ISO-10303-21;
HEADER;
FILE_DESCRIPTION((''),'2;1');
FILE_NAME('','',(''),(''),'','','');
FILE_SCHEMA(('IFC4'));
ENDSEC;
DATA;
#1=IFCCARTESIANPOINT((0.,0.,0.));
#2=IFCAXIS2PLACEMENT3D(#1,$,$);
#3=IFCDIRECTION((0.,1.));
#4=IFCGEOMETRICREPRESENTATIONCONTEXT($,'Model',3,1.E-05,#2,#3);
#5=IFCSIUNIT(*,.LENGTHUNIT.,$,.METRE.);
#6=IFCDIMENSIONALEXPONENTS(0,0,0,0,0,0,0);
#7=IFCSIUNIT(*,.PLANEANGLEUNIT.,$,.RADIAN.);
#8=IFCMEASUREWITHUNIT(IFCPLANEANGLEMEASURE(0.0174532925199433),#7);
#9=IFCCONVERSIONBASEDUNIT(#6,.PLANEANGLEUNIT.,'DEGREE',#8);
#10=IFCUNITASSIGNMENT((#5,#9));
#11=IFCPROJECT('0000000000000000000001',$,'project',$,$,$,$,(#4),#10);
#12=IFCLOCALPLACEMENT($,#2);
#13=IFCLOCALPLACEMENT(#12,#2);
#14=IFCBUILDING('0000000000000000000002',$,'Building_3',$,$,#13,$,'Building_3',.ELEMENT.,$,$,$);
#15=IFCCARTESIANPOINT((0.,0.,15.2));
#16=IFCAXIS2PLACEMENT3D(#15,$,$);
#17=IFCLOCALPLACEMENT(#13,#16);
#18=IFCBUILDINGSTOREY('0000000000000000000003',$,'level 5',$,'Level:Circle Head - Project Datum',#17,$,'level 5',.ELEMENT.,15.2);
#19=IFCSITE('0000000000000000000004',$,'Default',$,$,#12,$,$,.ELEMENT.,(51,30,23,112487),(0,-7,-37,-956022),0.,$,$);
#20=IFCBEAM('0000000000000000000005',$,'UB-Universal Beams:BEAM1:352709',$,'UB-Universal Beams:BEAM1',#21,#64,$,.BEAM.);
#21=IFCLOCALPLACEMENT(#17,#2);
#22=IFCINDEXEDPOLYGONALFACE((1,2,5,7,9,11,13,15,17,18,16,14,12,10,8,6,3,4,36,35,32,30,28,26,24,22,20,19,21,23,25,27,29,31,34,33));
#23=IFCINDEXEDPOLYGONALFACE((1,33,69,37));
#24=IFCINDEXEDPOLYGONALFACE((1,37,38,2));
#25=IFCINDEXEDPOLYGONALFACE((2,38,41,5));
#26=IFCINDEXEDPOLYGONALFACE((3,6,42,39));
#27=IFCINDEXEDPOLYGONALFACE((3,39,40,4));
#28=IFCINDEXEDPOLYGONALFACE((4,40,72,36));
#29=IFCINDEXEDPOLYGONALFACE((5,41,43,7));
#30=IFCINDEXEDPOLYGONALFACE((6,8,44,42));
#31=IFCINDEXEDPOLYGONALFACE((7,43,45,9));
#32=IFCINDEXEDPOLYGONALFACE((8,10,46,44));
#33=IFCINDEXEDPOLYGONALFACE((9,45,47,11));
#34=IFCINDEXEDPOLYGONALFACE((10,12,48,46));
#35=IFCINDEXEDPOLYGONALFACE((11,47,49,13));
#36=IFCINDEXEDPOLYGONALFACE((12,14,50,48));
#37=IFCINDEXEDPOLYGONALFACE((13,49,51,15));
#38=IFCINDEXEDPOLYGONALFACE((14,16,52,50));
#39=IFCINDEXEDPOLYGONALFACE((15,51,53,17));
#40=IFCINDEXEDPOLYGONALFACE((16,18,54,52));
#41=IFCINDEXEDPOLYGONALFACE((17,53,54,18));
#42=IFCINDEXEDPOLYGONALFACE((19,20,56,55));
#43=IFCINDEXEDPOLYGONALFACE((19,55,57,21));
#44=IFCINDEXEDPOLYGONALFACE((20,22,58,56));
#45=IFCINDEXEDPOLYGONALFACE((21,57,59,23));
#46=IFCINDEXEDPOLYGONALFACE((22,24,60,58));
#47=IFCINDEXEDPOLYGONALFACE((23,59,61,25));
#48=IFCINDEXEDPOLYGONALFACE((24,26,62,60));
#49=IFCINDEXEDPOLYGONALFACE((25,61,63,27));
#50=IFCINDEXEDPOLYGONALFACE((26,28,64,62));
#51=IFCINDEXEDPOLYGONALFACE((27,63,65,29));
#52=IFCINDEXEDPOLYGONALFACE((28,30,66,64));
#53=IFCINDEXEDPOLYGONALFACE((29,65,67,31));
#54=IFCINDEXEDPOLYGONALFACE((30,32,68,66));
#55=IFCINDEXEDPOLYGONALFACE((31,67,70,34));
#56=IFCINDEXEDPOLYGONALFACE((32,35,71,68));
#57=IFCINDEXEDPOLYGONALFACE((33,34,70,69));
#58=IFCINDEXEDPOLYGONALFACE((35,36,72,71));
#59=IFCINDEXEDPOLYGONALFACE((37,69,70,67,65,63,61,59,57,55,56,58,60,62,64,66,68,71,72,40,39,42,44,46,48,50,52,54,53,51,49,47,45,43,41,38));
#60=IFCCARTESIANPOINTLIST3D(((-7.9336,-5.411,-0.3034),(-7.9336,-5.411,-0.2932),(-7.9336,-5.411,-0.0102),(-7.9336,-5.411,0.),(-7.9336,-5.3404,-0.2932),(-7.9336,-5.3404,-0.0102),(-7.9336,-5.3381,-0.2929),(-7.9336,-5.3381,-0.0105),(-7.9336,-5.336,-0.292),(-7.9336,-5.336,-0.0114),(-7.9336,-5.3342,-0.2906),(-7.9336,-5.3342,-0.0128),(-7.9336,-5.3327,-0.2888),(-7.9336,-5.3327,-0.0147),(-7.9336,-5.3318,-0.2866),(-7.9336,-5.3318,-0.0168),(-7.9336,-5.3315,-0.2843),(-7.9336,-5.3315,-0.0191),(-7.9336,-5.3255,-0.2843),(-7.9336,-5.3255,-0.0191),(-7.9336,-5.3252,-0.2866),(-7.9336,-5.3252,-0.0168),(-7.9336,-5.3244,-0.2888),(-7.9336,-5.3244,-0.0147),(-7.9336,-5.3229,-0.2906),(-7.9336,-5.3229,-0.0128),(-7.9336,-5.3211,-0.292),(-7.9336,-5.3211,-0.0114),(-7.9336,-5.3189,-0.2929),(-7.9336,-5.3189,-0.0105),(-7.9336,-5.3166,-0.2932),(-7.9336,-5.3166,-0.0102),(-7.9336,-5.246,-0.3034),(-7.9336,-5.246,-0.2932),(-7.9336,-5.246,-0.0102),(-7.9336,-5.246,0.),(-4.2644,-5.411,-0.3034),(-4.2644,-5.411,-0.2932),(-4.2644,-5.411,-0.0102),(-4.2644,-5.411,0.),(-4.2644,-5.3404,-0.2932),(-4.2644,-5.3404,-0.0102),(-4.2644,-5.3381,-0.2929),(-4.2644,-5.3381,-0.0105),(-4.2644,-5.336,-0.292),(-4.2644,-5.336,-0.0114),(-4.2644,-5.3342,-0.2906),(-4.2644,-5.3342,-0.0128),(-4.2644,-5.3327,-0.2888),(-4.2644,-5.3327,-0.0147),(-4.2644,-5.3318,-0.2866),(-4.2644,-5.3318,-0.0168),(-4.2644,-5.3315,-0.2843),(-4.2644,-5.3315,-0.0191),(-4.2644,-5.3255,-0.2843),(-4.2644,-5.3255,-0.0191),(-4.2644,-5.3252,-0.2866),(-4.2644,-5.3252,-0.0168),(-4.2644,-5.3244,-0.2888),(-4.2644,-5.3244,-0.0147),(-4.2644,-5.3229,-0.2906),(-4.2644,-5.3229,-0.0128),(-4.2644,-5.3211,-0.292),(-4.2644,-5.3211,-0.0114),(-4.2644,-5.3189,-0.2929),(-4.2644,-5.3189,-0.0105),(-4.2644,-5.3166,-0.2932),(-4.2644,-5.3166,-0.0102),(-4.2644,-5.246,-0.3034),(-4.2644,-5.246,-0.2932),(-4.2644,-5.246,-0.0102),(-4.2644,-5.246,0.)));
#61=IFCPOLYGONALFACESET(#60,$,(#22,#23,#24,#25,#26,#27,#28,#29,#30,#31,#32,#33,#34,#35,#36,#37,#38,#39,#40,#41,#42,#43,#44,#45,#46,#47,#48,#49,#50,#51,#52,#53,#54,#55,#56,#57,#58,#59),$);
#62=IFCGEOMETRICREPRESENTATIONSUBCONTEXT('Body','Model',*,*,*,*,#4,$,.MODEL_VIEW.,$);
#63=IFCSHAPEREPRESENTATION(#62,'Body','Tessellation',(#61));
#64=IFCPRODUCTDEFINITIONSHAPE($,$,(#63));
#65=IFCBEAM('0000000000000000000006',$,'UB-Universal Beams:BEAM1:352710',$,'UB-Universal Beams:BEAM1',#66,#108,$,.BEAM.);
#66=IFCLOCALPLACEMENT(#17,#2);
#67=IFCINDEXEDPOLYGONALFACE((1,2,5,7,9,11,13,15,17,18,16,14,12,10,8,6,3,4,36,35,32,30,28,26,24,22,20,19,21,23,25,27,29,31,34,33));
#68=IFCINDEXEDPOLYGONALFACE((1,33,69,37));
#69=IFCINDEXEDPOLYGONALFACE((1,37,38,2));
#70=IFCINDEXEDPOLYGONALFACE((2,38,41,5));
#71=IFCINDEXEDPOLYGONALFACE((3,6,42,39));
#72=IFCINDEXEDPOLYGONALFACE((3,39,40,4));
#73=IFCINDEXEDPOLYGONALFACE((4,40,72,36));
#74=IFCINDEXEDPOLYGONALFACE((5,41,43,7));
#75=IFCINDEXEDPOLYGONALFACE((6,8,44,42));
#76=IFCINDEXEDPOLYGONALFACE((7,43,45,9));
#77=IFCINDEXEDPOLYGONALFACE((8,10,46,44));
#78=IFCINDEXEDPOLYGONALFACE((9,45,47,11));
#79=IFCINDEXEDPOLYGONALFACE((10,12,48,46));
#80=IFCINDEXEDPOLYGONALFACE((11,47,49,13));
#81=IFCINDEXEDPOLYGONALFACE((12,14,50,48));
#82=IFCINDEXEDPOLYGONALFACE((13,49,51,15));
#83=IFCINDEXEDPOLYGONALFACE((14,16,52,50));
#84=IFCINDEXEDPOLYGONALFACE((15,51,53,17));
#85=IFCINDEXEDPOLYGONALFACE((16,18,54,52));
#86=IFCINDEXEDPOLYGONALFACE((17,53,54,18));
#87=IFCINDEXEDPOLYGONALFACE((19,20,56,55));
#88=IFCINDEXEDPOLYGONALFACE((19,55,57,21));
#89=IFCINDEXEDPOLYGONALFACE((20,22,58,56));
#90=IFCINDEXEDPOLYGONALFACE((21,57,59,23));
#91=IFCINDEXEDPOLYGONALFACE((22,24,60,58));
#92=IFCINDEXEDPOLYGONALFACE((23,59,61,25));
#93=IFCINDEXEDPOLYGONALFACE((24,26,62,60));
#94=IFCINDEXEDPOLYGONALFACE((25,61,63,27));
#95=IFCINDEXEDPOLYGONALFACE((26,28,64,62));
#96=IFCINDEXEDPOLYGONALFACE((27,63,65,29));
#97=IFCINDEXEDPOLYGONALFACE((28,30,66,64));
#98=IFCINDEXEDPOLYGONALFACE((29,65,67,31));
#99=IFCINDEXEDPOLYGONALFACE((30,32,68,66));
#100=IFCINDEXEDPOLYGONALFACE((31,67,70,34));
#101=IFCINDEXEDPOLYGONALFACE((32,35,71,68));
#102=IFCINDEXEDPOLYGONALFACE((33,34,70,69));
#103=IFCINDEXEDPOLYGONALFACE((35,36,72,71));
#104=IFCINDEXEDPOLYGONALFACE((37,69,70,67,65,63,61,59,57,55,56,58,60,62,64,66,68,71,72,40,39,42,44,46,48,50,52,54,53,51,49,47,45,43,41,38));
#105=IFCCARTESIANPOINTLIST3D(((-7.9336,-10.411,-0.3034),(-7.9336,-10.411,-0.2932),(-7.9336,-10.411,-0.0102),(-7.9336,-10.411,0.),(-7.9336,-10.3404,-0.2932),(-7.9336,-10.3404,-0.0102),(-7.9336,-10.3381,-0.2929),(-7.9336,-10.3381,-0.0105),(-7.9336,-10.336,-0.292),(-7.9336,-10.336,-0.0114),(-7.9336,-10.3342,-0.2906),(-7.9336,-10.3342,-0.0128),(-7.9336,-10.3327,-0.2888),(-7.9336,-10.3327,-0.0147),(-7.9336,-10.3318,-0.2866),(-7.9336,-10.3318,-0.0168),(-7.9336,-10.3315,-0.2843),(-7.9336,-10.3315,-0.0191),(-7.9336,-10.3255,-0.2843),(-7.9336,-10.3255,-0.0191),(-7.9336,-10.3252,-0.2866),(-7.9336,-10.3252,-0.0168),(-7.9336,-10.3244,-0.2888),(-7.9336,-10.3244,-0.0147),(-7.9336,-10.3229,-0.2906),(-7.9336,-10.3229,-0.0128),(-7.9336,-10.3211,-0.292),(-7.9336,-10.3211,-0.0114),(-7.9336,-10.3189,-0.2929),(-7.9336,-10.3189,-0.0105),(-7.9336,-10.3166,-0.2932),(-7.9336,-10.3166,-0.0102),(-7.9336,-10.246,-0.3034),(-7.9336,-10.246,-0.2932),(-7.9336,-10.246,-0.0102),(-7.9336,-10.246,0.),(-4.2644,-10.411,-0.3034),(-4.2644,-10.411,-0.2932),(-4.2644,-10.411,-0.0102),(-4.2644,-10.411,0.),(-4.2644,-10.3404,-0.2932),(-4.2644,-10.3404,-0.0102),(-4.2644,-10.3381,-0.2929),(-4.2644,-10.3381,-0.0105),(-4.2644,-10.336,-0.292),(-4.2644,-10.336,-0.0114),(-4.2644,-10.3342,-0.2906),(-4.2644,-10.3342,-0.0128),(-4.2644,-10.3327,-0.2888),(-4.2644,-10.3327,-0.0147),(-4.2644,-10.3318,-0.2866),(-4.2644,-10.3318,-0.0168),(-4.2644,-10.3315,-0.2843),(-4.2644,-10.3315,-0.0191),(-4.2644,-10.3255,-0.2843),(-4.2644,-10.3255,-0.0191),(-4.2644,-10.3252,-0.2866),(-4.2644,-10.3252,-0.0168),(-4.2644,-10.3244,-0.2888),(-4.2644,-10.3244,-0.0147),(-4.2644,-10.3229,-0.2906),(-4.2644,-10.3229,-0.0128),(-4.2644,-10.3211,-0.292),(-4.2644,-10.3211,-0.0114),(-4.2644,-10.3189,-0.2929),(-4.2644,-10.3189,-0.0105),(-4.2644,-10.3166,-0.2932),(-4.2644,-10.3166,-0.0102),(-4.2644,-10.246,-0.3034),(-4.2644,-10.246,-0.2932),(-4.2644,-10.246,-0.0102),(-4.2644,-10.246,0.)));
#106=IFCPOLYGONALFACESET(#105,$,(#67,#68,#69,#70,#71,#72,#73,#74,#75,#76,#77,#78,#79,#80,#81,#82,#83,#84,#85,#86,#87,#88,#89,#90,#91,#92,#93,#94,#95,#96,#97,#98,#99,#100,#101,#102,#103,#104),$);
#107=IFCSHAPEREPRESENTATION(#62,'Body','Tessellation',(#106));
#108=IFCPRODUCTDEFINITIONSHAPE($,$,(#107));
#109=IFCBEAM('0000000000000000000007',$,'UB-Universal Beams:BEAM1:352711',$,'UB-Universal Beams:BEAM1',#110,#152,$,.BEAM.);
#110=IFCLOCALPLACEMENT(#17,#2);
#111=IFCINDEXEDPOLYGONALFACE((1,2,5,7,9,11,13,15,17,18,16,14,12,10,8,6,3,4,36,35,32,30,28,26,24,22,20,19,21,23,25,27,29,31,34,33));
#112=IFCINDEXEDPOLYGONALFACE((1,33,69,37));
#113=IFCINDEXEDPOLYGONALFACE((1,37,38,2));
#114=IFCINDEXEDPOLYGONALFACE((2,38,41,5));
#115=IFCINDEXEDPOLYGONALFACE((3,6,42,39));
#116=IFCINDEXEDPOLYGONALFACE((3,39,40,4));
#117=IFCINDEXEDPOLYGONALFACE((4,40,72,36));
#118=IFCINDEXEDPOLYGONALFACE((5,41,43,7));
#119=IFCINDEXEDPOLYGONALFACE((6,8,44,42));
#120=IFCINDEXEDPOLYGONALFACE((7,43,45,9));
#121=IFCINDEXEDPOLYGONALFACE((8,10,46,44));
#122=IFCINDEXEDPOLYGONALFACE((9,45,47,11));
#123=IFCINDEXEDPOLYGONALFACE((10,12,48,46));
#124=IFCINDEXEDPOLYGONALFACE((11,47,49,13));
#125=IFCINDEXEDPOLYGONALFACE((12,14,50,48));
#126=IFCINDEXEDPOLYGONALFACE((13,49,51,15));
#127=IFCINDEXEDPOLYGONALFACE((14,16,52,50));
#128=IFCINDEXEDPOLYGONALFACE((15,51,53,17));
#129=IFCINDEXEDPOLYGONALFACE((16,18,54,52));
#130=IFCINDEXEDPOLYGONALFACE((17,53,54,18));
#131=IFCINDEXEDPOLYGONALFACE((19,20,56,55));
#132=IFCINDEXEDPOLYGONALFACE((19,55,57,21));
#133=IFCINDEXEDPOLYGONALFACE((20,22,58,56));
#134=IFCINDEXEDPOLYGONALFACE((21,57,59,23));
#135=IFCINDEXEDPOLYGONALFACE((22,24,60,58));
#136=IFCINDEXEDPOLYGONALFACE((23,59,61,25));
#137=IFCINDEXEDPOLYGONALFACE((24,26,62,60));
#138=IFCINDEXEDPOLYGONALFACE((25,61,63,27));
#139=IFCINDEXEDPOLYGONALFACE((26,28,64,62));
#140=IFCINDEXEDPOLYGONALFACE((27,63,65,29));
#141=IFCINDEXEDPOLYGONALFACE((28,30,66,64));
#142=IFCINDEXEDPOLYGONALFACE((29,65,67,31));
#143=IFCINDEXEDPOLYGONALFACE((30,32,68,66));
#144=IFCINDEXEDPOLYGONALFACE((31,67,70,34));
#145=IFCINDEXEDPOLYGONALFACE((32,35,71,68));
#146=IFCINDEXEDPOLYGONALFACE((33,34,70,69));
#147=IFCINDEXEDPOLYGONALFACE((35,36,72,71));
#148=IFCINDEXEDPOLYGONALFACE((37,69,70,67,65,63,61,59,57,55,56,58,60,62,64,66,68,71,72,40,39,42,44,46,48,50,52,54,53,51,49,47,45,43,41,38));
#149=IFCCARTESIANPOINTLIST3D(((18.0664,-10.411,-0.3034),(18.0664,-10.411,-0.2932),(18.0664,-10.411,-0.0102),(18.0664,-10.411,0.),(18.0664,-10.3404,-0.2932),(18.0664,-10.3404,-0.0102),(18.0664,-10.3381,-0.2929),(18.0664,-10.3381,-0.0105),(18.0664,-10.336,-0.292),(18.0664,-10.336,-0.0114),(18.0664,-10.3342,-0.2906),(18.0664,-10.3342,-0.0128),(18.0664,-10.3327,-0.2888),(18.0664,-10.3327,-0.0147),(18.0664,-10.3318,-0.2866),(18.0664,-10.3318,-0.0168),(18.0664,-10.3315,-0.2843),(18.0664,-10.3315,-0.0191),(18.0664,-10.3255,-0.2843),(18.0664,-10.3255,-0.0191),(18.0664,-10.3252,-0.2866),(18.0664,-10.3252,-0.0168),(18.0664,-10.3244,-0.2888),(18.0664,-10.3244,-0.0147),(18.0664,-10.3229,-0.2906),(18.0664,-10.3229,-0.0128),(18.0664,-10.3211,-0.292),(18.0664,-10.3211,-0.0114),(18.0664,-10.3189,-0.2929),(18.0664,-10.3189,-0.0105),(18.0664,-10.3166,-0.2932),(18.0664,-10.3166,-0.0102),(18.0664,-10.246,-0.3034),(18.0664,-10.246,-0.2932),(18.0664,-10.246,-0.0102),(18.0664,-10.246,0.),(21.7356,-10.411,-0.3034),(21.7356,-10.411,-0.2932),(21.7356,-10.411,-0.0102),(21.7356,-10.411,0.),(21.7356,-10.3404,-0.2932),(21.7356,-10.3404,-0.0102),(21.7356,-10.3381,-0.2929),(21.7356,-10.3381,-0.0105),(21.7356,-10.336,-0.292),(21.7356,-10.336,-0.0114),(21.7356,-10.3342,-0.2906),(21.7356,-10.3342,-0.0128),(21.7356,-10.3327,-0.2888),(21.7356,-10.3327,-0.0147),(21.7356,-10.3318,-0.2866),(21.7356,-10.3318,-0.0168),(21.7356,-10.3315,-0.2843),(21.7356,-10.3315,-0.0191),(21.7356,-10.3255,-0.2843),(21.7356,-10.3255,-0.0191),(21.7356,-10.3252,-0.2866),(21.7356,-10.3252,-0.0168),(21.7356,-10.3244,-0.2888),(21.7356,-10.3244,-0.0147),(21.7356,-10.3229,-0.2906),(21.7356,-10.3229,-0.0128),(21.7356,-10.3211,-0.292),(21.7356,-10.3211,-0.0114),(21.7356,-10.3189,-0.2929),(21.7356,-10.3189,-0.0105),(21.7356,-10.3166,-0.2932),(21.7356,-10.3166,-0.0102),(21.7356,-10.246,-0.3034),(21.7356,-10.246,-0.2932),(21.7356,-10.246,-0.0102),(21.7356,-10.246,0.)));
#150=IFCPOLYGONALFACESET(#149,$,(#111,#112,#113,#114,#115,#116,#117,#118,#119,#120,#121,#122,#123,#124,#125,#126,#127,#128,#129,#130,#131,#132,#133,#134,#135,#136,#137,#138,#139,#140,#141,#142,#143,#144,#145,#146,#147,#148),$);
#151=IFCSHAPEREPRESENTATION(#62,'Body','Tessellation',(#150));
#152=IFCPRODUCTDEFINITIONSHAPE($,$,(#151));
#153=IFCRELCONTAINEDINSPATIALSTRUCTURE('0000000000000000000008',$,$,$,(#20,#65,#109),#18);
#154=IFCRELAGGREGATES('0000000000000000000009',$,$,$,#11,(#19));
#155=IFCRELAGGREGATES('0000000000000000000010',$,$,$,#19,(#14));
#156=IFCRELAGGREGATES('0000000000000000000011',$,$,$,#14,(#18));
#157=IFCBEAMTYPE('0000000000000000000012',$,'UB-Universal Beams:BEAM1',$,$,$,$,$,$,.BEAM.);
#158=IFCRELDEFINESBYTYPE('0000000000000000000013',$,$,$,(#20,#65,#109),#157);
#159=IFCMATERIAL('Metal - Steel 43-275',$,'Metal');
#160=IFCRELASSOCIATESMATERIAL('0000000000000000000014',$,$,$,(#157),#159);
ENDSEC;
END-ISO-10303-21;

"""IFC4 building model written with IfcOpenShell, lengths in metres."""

from ifc_helpers import new_model, entity, si_unit, converted_unit, direction, frame, frame_2d, origin, place, context, subcontext, project, spatial, polyline, circle_curve, parameter, trimmed, segment, composite_curve, outline, extrude, source, transform, mapped, material, material_profile, profile_set, type_object, type_shapes, element, save


model = new_model("IFC4")

# Units and contexts
model_context = context("Model", 3, precision=1e-05, world=origin(), true_north=direction((0.0, 1.0)))
body_context = subcontext(model_context, "Body", "Model", "MODEL_VIEW")
ifc_project = project(units=[si_unit("LENGTHUNIT", "METRE"), converted_unit("PLANEANGLEUNIT", "DEGREE", entity("IfcPlaneAngleMeasure", 0.0174532925199433), si_unit("PLANEANGLEUNIT", "RADIAN"), dimensions=[0, 0, 0, 0, 0, 0, 0])], contexts=[model_context])

# Site, building, storey
site_placement = place(None, origin())
site = spatial("IfcSite", under=ifc_project, at=site_placement, Name="Default", CompositionType="ELEMENT", RefLatitude=(51, 30, 23, 112487), RefLongitude=(0, -7, -37, -956022), RefElevation=0.0)
building_placement = place(site_placement, origin())
building = spatial("IfcBuilding", under=site, at=building_placement, Name="Building_3", LongName="Building_3", CompositionType="ELEMENT")
storey_placement = place(building_placement, frame((0.0, 0.0, 15.2)))
storey = spatial("IfcBuildingStorey", under=building, at=storey_placement, Name="level 5", ObjectType="Level:Circle Head - Project Datum", LongName="level 5", CompositionType="ELEMENT", Elevation=15.2)

# Beams
ifc_material_1 = material(Name="Metal - Steel 43-275", Category="Metal")
ifc_material_profile = material_profile(ifc_material_1, outline(composite_curve([segment(polyline([(-0.0825, -0.1415), (-0.0825, -0.1517)]), True, "CONTINUOUS"), segment(polyline([(-0.0825, -0.1517), (0.0825, -0.1517)]), True, "CONTINUOUS"), segment(polyline([(0.0825, -0.1517), (0.0825, -0.1415)]), True, "CONTINUOUS"), segment(polyline([(0.0825, -0.1415), (0.0119, -0.1415)]), True, "CONTINUOUS"), segment(trimmed(circle_curve(frame_2d((0.0119, -0.1326), x_axis=(1.0, 0.0)), 0.0089), [parameter(180.0)], [parameter(270.0)], True, "PARAMETER"), False, "CONTINUOUS"), segment(polyline([(0.003, -0.1326), (0.003, 0.1326)]), True, "CONTINUOUS"), segment(trimmed(circle_curve(frame_2d((0.0119, 0.1326), x_axis=(1.0, 0.0)), 0.0089), [parameter(90.0)], [parameter(180.0)], True, "PARAMETER"), False, "CONTINUOUS"), segment(polyline([(0.0119, 0.1415), (0.0825, 0.1415)]), True, "CONTINUOUS"), segment(polyline([(0.0825, 0.1415), (0.0825, 0.1517)]), True, "CONTINUOUS"), segment(polyline([(0.0825, 0.1517), (-0.0825, 0.1517)]), True, "CONTINUOUS"), segment(polyline([(-0.0825, 0.1517), (-0.0825, 0.1415)]), True, "CONTINUOUS"), segment(polyline([(-0.0825, 0.1415), (-0.0119, 0.1415)]), True, "CONTINUOUS"), segment(trimmed(circle_curve(frame_2d((-0.0119, 0.1326), x_axis=(1.0, 0.0)), 0.0089), [parameter(360.0)], [parameter(90.0)], True, "PARAMETER"), False, "CONTINUOUS"), segment(polyline([(-0.003, 0.1326), (-0.003, -0.1326)]), True, "CONTINUOUS"), segment(trimmed(circle_curve(frame_2d((-0.0119, -0.1326), x_axis=(1.0, 0.0)), 0.0089), [parameter(270.0)], [parameter(360.0)], True, "PARAMETER"), False, "CONTINUOUS"), segment(polyline([(-0.0119, -0.1415), (-0.0825, -0.1415)]), True, "CONTINUOUS")], self_intersect=False)), Name="BEAM1")
ifc_profile_set = profile_set([ifc_material_profile], Name="BEAM1")
beam_type_1 = type_object("IfcBeamType", Name="UB-Universal Beams:BEAM1", PredefinedType="BEAM", material=ifc_profile_set)
shared_shape_1 = source(origin(), body_context, "Body", "SweptSolid", [
    extrude(outline(composite_curve([segment(polyline([(-0.0825, -0.1415), (-0.0825, -0.1517)]), True, "CONTINUOUS"), segment(polyline([(-0.0825, -0.1517), (0.0825, -0.1517)]), True, "CONTINUOUS"), segment(polyline([(0.0825, -0.1517), (0.0825, -0.1415)]), True, "CONTINUOUS"), segment(polyline([(0.0825, -0.1415), (0.0119, -0.1415)]), True, "CONTINUOUS"), segment(trimmed(circle_curve(frame_2d((0.0119, -0.1326), x_axis=(0.0, -1.0)), 0.0089), [parameter(270.0)], [parameter(360.0)], True, "PARAMETER"), False, "CONTINUOUS"), segment(polyline([(0.003, -0.1326), (0.003, 0.1326)]), True, "CONTINUOUS"), segment(trimmed(circle_curve(frame_2d((0.0119, 0.1326), x_axis=(-1.0, 0.0)), 0.0089), [parameter(270.0)], [parameter(360.0)], True, "PARAMETER"), False, "CONTINUOUS"), segment(polyline([(0.0119, 0.1415), (0.0825, 0.1415)]), True, "CONTINUOUS"), segment(polyline([(0.0825, 0.1415), (0.0825, 0.1517)]), True, "CONTINUOUS"), segment(polyline([(0.0825, 0.1517), (-0.0825, 0.1517)]), True, "CONTINUOUS"), segment(polyline([(-0.0825, 0.1517), (-0.0825, 0.1415)]), True, "CONTINUOUS"), segment(polyline([(-0.0825, 0.1415), (-0.0119, 0.1415)]), True, "CONTINUOUS"), segment(trimmed(circle_curve(frame_2d((-0.0119, 0.1326), x_axis=(0.0, 1.0)), 0.0089), [parameter(270.0)], [parameter(360.0)], True, "PARAMETER"), False, "CONTINUOUS"), segment(polyline([(-0.003, 0.1326), (-0.003, -0.1326)]), True, "CONTINUOUS"), segment(trimmed(circle_curve(frame_2d((-0.0119, -0.1326), x_axis=(1.0, 0.0)), 0.0089), [parameter(270.0)], [parameter(0.0)], True, "PARAMETER"), False, "CONTINUOUS"), segment(polyline([(-0.0119, -0.1415), (-0.0825, -0.1415)]), True, "CONTINUOUS")], self_intersect=False)), frame((-1.8346, 0.0, 0.0), z_axis=(-1.0, 0.0, 0.0), x_axis=(0.0, -1.0, 0.0)), (0.0, 0.0, -1.0), 3.6692),
])
type_shapes(beam_type_1, [shared_shape_1])
for number, where, name in (
    (1, (-6.099, -5.3285, -0.1517), "UB-Universal Beams:BEAM1:352709"),
    (2, (-6.099, -10.3285, -0.1517), "UB-Universal Beams:BEAM1:352710"),
    (3, (19.901, -10.3285, -0.1517), "UB-Universal Beams:BEAM1:352711"),
):
    element("IfcBeam", number, at=place(storey_placement, frame(where)), inside=storey, type_object=beam_type_1, Name=name, ObjectType="UB-Universal Beams:BEAM1", PredefinedType="BEAM", context=body_context, shape_type="MappedRepresentation", body=[
        mapped(shared_shape_1, transform((0.0, 0.0, 0.0), scale=1.0)),
    ])

save(model, "model.ifc")
